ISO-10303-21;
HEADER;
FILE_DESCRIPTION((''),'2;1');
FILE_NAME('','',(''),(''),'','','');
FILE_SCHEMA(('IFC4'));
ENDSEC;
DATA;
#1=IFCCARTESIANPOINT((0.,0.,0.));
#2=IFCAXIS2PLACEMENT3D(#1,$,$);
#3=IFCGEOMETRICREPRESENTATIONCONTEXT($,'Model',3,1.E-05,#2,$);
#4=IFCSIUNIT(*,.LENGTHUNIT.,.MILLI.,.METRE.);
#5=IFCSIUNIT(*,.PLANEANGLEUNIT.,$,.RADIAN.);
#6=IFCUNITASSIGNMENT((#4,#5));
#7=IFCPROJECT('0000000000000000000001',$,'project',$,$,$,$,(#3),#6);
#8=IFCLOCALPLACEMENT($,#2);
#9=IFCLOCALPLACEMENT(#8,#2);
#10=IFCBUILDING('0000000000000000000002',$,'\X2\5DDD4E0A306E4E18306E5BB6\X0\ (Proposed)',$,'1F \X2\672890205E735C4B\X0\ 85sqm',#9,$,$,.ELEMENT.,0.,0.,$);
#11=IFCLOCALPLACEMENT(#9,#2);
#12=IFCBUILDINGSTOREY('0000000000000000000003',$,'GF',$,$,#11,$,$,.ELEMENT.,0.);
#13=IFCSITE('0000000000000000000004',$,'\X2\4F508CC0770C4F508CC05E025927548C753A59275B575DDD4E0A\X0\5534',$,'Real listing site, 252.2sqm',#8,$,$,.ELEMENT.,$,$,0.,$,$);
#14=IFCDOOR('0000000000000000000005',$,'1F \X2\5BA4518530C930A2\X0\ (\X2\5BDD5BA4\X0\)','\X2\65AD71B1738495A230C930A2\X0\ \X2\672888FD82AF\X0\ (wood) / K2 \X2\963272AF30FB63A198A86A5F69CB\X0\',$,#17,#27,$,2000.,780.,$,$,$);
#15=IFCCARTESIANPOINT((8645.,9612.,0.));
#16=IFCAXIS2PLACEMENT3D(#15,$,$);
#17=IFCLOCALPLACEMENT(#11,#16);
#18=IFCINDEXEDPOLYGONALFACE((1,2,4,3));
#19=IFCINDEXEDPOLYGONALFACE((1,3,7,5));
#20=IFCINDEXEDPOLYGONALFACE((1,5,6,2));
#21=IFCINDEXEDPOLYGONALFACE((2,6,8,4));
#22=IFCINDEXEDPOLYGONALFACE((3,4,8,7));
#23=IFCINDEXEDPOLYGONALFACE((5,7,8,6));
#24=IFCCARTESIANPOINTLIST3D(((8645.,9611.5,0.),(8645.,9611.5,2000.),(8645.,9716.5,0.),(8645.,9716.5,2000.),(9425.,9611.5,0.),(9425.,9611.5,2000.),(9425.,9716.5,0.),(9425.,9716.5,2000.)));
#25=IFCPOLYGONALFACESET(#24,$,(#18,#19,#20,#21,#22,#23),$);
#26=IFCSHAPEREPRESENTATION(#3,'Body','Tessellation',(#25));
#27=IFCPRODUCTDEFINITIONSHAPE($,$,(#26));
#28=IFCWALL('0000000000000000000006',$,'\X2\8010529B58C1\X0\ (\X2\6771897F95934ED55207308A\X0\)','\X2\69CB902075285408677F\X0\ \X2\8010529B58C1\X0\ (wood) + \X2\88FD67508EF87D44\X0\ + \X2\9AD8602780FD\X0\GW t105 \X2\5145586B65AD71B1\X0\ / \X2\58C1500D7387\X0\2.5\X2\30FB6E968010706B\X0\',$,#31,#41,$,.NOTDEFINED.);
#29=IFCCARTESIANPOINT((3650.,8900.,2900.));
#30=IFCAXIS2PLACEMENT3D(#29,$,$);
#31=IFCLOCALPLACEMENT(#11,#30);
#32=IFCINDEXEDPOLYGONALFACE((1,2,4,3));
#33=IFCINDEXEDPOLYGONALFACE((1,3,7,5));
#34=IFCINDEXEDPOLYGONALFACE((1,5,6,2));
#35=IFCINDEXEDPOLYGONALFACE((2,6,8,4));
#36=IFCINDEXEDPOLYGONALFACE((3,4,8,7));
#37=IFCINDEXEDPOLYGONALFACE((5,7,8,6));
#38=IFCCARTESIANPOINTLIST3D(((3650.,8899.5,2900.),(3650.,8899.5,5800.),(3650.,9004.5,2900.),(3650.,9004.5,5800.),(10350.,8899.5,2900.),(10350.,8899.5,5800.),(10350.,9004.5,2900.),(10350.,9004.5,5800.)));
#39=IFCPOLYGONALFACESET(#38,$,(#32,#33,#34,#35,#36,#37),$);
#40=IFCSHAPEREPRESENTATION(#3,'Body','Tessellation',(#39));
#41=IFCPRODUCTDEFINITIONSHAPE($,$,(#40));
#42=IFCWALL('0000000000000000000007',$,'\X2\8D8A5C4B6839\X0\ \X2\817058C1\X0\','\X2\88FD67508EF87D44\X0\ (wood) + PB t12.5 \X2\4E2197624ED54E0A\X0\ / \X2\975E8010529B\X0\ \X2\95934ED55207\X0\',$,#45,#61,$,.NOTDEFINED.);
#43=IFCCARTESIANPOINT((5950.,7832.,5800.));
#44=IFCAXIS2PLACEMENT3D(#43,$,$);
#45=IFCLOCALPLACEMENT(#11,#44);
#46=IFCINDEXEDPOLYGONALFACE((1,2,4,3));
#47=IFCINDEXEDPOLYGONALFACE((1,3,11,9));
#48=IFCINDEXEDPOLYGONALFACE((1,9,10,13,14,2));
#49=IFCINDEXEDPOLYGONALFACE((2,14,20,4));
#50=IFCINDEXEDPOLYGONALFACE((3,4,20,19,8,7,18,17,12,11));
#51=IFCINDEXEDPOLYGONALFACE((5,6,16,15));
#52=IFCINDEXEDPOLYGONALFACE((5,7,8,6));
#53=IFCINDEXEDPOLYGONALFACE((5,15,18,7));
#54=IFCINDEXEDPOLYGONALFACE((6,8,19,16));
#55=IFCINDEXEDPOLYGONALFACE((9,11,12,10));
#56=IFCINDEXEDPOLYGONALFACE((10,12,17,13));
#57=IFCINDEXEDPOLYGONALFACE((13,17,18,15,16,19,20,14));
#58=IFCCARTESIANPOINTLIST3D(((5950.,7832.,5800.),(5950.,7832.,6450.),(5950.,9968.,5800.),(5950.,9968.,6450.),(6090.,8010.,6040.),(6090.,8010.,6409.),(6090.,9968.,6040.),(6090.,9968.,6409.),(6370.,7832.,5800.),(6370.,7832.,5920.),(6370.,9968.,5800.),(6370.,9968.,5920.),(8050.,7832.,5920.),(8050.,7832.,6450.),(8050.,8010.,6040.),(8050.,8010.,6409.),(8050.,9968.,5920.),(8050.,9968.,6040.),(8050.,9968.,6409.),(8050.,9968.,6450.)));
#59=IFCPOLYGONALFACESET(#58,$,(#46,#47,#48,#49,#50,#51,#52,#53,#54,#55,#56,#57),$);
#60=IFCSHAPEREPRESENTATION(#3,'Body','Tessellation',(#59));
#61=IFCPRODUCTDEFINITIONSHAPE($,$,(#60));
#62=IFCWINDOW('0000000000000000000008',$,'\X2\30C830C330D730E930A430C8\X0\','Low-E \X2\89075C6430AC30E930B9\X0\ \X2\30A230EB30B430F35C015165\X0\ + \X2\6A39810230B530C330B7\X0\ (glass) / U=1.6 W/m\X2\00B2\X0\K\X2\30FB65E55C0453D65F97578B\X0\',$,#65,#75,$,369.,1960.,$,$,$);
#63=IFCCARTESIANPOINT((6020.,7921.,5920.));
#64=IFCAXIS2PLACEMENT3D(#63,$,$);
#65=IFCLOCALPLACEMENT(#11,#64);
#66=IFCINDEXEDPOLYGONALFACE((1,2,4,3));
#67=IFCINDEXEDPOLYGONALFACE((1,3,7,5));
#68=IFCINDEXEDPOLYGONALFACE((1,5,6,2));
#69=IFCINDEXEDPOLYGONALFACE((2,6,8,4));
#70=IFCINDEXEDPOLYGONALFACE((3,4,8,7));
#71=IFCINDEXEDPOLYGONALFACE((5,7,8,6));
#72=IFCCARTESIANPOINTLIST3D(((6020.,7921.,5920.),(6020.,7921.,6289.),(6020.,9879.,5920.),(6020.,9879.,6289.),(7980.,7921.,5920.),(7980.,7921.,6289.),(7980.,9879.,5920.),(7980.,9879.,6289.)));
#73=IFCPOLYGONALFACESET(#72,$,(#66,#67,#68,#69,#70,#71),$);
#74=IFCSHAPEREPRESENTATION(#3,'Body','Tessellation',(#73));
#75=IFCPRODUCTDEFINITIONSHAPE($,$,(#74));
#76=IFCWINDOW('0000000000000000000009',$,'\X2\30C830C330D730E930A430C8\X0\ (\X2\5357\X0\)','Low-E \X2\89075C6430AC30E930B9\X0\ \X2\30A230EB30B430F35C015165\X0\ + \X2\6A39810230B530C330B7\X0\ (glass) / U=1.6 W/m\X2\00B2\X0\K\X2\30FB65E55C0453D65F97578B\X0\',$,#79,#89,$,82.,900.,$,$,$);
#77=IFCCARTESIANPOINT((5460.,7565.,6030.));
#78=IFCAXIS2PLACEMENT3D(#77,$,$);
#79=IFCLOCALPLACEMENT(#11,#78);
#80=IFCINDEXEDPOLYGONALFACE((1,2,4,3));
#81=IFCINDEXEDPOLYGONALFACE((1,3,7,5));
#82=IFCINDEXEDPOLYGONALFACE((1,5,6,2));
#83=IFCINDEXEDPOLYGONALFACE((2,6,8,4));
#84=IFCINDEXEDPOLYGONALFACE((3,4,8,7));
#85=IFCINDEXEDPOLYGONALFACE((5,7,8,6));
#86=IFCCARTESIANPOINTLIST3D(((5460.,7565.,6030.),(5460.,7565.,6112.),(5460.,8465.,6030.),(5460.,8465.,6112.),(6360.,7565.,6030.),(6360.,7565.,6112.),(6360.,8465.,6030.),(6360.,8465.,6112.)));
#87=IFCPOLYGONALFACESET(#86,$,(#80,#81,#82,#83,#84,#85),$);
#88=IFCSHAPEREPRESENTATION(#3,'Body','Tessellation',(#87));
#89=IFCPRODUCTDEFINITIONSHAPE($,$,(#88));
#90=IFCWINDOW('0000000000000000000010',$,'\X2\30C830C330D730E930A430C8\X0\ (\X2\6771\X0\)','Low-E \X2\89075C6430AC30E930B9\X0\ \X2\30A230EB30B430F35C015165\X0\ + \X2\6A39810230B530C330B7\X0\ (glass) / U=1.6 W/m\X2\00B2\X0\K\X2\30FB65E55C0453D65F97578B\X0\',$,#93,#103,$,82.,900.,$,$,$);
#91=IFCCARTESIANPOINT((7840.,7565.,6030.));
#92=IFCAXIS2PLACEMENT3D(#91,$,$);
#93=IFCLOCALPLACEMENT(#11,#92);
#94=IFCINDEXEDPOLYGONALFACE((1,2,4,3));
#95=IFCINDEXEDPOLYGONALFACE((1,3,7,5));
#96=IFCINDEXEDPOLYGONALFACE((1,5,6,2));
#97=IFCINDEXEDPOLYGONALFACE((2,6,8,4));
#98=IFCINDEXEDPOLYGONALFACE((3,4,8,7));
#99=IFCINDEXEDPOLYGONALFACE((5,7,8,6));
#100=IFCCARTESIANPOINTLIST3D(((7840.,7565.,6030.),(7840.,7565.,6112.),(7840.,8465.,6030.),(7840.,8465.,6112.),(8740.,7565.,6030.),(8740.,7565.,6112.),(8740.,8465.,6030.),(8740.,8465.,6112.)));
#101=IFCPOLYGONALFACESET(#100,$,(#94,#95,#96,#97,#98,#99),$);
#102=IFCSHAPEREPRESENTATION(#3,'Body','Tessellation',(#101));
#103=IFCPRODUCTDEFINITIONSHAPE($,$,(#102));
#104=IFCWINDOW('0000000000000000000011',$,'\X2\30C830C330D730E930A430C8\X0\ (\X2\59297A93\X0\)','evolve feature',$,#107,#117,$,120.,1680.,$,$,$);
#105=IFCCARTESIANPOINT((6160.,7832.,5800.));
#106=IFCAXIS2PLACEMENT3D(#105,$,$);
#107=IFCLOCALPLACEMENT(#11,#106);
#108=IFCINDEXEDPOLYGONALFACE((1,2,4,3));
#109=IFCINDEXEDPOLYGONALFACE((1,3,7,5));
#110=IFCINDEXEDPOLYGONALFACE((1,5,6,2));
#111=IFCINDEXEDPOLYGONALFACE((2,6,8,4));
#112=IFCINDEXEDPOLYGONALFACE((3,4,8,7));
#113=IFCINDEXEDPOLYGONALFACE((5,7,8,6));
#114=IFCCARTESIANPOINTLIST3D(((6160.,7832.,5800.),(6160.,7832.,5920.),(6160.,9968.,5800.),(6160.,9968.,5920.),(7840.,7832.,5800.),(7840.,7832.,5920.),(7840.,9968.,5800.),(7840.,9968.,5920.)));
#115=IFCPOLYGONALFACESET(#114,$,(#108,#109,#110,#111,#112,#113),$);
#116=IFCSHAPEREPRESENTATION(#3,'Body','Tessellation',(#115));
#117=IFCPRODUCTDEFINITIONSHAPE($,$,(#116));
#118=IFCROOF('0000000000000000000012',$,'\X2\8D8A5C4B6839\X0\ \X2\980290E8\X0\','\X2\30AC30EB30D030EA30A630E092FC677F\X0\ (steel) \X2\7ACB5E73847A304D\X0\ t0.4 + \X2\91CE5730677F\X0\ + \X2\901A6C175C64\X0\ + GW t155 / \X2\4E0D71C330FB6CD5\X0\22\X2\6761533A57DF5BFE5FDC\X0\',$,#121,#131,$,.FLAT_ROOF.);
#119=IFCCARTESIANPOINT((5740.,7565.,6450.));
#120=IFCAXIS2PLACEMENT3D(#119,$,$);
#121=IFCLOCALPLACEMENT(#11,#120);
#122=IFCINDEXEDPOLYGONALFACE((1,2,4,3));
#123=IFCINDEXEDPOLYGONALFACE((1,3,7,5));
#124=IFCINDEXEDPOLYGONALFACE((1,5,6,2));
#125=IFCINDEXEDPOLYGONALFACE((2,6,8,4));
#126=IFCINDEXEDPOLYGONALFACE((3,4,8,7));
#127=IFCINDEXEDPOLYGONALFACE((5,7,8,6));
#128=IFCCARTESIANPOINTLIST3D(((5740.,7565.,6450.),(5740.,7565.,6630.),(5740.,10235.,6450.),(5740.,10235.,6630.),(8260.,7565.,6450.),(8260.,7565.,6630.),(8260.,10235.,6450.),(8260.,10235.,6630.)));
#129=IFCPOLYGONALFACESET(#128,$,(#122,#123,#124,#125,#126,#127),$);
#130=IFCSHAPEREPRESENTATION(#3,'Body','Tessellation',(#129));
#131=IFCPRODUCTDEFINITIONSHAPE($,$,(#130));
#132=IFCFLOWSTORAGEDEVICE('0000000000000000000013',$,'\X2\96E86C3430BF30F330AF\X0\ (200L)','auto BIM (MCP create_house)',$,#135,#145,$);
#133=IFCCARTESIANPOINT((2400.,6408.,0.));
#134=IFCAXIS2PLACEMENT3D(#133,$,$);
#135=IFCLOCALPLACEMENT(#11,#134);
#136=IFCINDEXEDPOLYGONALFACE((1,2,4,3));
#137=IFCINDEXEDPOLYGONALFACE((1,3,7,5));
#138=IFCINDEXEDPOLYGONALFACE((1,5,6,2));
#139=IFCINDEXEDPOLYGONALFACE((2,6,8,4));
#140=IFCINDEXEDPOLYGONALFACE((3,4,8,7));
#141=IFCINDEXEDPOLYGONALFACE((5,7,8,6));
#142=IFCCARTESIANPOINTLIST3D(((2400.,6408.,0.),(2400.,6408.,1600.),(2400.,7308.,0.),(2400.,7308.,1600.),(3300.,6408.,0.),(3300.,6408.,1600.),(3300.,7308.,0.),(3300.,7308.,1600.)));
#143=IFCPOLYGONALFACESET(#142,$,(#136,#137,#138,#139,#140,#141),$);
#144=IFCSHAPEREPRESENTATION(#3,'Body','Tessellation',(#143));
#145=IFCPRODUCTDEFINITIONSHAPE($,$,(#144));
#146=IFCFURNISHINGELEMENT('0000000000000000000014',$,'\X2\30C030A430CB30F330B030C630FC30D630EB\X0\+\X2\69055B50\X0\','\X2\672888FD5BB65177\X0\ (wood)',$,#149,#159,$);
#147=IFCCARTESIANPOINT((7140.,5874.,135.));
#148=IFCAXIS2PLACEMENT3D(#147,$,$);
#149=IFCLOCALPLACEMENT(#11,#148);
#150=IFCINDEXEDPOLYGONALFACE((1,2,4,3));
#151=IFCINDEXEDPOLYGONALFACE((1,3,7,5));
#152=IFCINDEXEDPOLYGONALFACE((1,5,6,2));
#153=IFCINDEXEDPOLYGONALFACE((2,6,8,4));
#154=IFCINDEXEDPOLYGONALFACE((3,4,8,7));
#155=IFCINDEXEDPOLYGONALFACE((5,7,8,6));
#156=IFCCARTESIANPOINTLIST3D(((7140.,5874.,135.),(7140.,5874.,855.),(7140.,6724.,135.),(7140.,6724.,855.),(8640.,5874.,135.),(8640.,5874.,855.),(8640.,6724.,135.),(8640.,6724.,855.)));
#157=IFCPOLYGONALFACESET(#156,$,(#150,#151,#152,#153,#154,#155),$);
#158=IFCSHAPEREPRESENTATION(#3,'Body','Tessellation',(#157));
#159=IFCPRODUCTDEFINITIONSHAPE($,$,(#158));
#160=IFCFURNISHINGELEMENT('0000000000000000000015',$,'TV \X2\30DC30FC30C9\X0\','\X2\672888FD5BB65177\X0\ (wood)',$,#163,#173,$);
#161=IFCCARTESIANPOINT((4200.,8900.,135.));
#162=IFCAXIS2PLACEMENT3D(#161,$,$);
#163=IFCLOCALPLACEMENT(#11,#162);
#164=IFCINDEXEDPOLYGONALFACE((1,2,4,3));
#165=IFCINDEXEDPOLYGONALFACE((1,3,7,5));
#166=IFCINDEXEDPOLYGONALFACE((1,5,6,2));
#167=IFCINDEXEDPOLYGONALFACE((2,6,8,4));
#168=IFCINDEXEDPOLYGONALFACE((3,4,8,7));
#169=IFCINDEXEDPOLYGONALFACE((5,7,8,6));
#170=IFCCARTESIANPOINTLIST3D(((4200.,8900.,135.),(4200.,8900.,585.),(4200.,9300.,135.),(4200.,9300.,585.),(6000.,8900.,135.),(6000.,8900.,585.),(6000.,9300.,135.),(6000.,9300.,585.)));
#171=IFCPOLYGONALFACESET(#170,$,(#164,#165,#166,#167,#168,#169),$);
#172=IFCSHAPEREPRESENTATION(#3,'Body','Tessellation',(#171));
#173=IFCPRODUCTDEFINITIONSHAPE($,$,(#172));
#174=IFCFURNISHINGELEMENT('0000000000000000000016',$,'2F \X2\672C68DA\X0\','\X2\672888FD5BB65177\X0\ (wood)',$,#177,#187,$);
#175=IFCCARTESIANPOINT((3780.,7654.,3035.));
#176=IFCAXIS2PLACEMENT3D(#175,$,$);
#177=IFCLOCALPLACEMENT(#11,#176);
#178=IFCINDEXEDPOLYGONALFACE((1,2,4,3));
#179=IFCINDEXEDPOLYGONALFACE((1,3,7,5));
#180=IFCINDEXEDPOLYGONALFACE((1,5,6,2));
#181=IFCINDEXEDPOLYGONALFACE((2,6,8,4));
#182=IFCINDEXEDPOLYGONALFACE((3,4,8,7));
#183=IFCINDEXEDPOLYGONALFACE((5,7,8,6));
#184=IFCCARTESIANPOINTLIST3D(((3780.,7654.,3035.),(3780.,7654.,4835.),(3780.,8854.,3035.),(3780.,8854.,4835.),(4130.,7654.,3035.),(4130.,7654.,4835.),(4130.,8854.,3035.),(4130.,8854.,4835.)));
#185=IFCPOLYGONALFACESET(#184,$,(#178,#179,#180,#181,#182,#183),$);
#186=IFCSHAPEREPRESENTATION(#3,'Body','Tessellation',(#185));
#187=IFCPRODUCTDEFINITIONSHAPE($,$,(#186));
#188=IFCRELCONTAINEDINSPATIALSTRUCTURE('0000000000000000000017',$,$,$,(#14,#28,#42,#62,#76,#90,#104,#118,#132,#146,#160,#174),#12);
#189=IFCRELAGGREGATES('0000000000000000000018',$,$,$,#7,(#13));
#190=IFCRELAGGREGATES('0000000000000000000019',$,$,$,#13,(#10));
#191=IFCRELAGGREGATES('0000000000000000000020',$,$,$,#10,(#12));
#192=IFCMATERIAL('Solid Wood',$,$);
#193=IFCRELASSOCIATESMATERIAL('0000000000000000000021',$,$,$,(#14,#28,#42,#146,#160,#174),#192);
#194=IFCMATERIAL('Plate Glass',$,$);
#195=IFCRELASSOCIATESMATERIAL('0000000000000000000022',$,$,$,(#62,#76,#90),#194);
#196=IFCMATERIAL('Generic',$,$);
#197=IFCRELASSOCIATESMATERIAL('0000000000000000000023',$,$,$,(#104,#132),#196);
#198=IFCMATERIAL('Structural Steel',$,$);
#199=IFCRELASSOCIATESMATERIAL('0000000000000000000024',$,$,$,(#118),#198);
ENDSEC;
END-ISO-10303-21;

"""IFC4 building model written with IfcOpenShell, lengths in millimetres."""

from ifc_helpers import new_model, si_unit, frame, frame_2d, origin, place, context, project, spatial, rectangle, extrude, material, element, fill, save


model = new_model("IFC4")

# Units and contexts
model_context = context("Model", 3, precision=1e-05, world=origin())
ifc_project = project(units=[si_unit("LENGTHUNIT", "METRE", prefix="MILLI"), si_unit("PLANEANGLEUNIT", "RADIAN")], contexts=[model_context])

# Site, building, storey
site_placement = place(None, origin())
site = spatial("IfcSite", under=ifc_project, at=site_placement, Name="佐賀県佐賀市大和町大字川上5534", ObjectType="Real listing site, 252.2sqm", CompositionType="ELEMENT", RefElevation=0.0)
building_placement = place(site_placement, origin())
building = spatial("IfcBuilding", under=site, at=building_placement, Name="川上の丘の家 (Proposed)", ObjectType="1F 木造平屋 85sqm", CompositionType="ELEMENT", ElevationOfRefHeight=0.0, ElevationOfTerrain=0.0)
storey_placement = place(building_placement, origin())
storey = spatial("IfcBuildingStorey", under=building, at=storey_placement, Name="GF", CompositionType="ELEMENT", Elevation=0.0)

# Shared definitions
ifc_material_1 = material(Name="Solid Wood")

# Door
door_placement = place(storey_placement, frame((8645.0, 9612.0, 0.0)))
element("IfcDoor", 1, at=door_placement, inside=storey, material=ifc_material_1, Name="1F 室内ドア (寝室)", Description="断熱玄関ドア 木製芯 (wood) / K2 防犯・採風機構", OverallHeight=2000.0, OverallWidth=780.0, context=model_context, shape_type="SweptSolid", body=[
    extrude(rectangle(XDim=780.0, YDim=105.0, at=frame_2d((390.0, 52.0))), frame((8645.0, 9612.0, 0.0)), (0.0, 0.0, 1.0), 2000.0),
])

# Wall
wall_1_placement = place(storey_placement, frame((3650.0, 8900.0, 2900.0)))
element("IfcWall", 2, at=wall_1_placement, inside=storey, material=ifc_material_1, Name="耐力壁 (東西間仕切り)", Description="構造用合板 耐力壁 (wood) + 製材軸組 + 高性能GW t105 充填断熱 / 壁倍率2.5・準耐火", PredefinedType="NOTDEFINED", context=model_context, shape_type="SweptSolid", body=[
    extrude(rectangle(XDim=6700.0, YDim=105.0, at=frame_2d((3350.0, 52.0))), frame((3650.0, 8900.0, 2900.0)), (0.0, 0.0, 1.0), 2900.0),
])

# Wall, openings, windows
wall_2_placement = place(storey_placement, frame((5950.0, 7832.0, 5800.0)))
wall_2 = element("IfcWall", 3, at=wall_2_placement, inside=storey, material=ifc_material_1, Name="越屋根 腰壁", Description="製材軸組 (wood) + PB t12.5 両面仕上 / 非耐力 間仕切", PredefinedType="NOTDEFINED", context=model_context, shape_type="SweptSolid", body=[
    extrude(rectangle(XDim=2100.0, YDim=2136.0, at=frame_2d((1050.0, 1068.0))), frame((5950.0, 7832.0, 5800.0)), (0.0, 0.0, 1.0), 650.0),
])
opening_1_placement = place(storey_placement, frame((6020.0, 7921.0, 5920.0)))
opening_1 = element("IfcOpeningElement", 4, at=opening_1_placement, cuts=wall_2, PredefinedType="NOTDEFINED", context=model_context, shape_type="SweptSolid", body=[
    extrude(rectangle(XDim=1960.0, YDim=1958.0, at=frame_2d((980.0, 979.0))), frame((6020.0, 7921.0, 5920.0)), (0.0, 0.0, 1.0), 369.0),
])
opening_2_placement = place(storey_placement, frame((5460.0, 7565.0, 6030.0)))
opening_2 = element("IfcOpeningElement", 5, at=opening_2_placement, cuts=wall_2, PredefinedType="NOTDEFINED", context=model_context, shape_type="SweptSolid", body=[
    extrude(rectangle(XDim=900.0, YDim=900.0, at=frame_2d((450.0, 450.0))), frame((5460.0, 7565.0, 6030.0)), (0.0, 0.0, 1.0), 82.0),
])
opening_3_placement = place(storey_placement, frame((7840.0, 7565.0, 6030.0)))
opening_3 = element("IfcOpeningElement", 6, at=opening_3_placement, cuts=wall_2, PredefinedType="NOTDEFINED", context=model_context, shape_type="SweptSolid", body=[
    extrude(rectangle(XDim=900.0, YDim=900.0, at=frame_2d((450.0, 450.0))), frame((7840.0, 7565.0, 6030.0)), (0.0, 0.0, 1.0), 82.0),
])
opening_4_placement = place(storey_placement, frame((6160.0, 7832.0, 5800.0)))
opening_4 = element("IfcOpeningElement", 7, at=opening_4_placement, cuts=wall_2, PredefinedType="NOTDEFINED", context=model_context, shape_type="SweptSolid", body=[
    extrude(rectangle(XDim=1680.0, YDim=2136.0, at=frame_2d((840.0, 1068.0))), frame((6160.0, 7832.0, 5800.0)), (0.0, 0.0, 1.0), 120.0),
])
ifc_material_2 = material(Name="Plate Glass")
window_1_placement = place(storey_placement, frame((6020.0, 7921.0, 5920.0)))
window_1 = element("IfcWindow", 8, at=window_1_placement, inside=storey, material=ifc_material_2, Name="トップライト", Description="Low-E 複層ガラス アルゴン封入 + 樹脂サッシ (glass) / U=1.6 W/m²K・日射取得型", OverallHeight=369.0, OverallWidth=1960.0, context=model_context, shape_type="SweptSolid", body=[
    extrude(rectangle(XDim=1960.0, YDim=1958.0, at=frame_2d((980.0, 979.0))), frame((6020.0, 7921.0, 5920.0)), (0.0, 0.0, 1.0), 369.0),
])
fill(opening_1, window_1)
window_2_placement = place(storey_placement, frame((5460.0, 7565.0, 6030.0)))
window_2 = element("IfcWindow", 9, at=window_2_placement, inside=storey, material=ifc_material_2, Name="トップライト (南)", Description="Low-E 複層ガラス アルゴン封入 + 樹脂サッシ (glass) / U=1.6 W/m²K・日射取得型", OverallHeight=82.0, OverallWidth=900.0, context=model_context, shape_type="SweptSolid", body=[
    extrude(rectangle(XDim=900.0, YDim=900.0, at=frame_2d((450.0, 450.0))), frame((5460.0, 7565.0, 6030.0)), (0.0, 0.0, 1.0), 82.0),
])
fill(opening_2, window_2)
window_3_placement = place(storey_placement, frame((7840.0, 7565.0, 6030.0)))
window_3 = element("IfcWindow", 10, at=window_3_placement, inside=storey, material=ifc_material_2, Name="トップライト (東)", Description="Low-E 複層ガラス アルゴン封入 + 樹脂サッシ (glass) / U=1.6 W/m²K・日射取得型", OverallHeight=82.0, OverallWidth=900.0, context=model_context, shape_type="SweptSolid", body=[
    extrude(rectangle(XDim=900.0, YDim=900.0, at=frame_2d((450.0, 450.0))), frame((7840.0, 7565.0, 6030.0)), (0.0, 0.0, 1.0), 82.0),
])
fill(opening_3, window_3)
ifc_material_3 = material(Name="Generic")
window_4_placement = place(storey_placement, frame((6160.0, 7832.0, 5800.0)))
window_4 = element("IfcWindow", 11, at=window_4_placement, inside=storey, material=ifc_material_3, Name="トップライト (天窓)", Description="evolve feature", OverallHeight=120.0, OverallWidth=1680.0, context=model_context, shape_type="SweptSolid", body=[
    extrude(rectangle(XDim=1680.0, YDim=2136.0, at=frame_2d((840.0, 1068.0))), frame((6160.0, 7832.0, 5800.0)), (0.0, 0.0, 1.0), 120.0),
])
fill(opening_4, window_4)

# Roof
ifc_material_4 = material(Name="Structural Steel")
roof_placement = place(storey_placement, frame((5740.0, 7565.0, 6450.0)))
element("IfcRoof", 12, at=roof_placement, inside=storey, material=ifc_material_4, Name="越屋根 頂部", Description="ガルバリウム鋼板 (steel) 立平葺き t0.4 + 野地板 + 通気層 + GW t155 / 不燃・法22条区域対応", PredefinedType="FLAT_ROOF", context=model_context, shape_type="SweptSolid", body=[
    extrude(rectangle(XDim=2520.0, YDim=2670.0, at=frame_2d((1260.0, 1335.0))), frame((5740.0, 7565.0, 6450.0)), (0.0, 0.0, 1.0), 180.0),
])

# Flow storage device
flow_storage_device_placement = place(storey_placement, frame((2400.0, 6408.0, 0.0)))
element("IfcFlowStorageDevice", 13, at=flow_storage_device_placement, inside=storey, material=ifc_material_3, Name="雨水タンク (200L)", Description="auto BIM (MCP create_house)", context=model_context, shape_type="SweptSolid", body=[
    extrude(rectangle(XDim=900.0, YDim=900.0, at=frame_2d((450.0, 450.0))), frame((2400.0, 6408.0, 0.0)), (0.0, 0.0, 1.0), 1600.0),
])

# Furnishing elements
furnishing_1_placement = place(storey_placement, frame((7140.0, 5874.0, 135.0)))
element("IfcFurnishingElement", 14, at=furnishing_1_placement, inside=storey, material=ifc_material_1, Name="ダイニングテーブル+椅子", Description="木製家具 (wood)", context=model_context, shape_type="SweptSolid", body=[
    extrude(rectangle(XDim=1500.0, YDim=850.0, at=frame_2d((750.0, 425.0))), frame((7140.0, 5874.0, 135.0)), (0.0, 0.0, 1.0), 720.0),
])
furnishing_2_placement = place(storey_placement, frame((4200.0, 8900.0, 135.0)))
element("IfcFurnishingElement", 15, at=furnishing_2_placement, inside=storey, material=ifc_material_1, Name="TV ボード", Description="木製家具 (wood)", context=model_context, shape_type="SweptSolid", body=[
    extrude(rectangle(XDim=1800.0, YDim=400.0, at=frame_2d((900.0, 200.0))), frame((4200.0, 8900.0, 135.0)), (0.0, 0.0, 1.0), 450.0),
])
furnishing_3_placement = place(storey_placement, frame((3780.0, 7654.0, 3035.0)))
element("IfcFurnishingElement", 16, at=furnishing_3_placement, inside=storey, material=ifc_material_1, Name="2F 本棚", Description="木製家具 (wood)", context=model_context, shape_type="SweptSolid", body=[
    extrude(rectangle(XDim=350.0, YDim=1200.0, at=frame_2d((175.0, 600.0))), frame((3780.0, 7654.0, 3035.0)), (0.0, 0.0, 1.0), 1800.0),
])

save(model, "model.ifc")
